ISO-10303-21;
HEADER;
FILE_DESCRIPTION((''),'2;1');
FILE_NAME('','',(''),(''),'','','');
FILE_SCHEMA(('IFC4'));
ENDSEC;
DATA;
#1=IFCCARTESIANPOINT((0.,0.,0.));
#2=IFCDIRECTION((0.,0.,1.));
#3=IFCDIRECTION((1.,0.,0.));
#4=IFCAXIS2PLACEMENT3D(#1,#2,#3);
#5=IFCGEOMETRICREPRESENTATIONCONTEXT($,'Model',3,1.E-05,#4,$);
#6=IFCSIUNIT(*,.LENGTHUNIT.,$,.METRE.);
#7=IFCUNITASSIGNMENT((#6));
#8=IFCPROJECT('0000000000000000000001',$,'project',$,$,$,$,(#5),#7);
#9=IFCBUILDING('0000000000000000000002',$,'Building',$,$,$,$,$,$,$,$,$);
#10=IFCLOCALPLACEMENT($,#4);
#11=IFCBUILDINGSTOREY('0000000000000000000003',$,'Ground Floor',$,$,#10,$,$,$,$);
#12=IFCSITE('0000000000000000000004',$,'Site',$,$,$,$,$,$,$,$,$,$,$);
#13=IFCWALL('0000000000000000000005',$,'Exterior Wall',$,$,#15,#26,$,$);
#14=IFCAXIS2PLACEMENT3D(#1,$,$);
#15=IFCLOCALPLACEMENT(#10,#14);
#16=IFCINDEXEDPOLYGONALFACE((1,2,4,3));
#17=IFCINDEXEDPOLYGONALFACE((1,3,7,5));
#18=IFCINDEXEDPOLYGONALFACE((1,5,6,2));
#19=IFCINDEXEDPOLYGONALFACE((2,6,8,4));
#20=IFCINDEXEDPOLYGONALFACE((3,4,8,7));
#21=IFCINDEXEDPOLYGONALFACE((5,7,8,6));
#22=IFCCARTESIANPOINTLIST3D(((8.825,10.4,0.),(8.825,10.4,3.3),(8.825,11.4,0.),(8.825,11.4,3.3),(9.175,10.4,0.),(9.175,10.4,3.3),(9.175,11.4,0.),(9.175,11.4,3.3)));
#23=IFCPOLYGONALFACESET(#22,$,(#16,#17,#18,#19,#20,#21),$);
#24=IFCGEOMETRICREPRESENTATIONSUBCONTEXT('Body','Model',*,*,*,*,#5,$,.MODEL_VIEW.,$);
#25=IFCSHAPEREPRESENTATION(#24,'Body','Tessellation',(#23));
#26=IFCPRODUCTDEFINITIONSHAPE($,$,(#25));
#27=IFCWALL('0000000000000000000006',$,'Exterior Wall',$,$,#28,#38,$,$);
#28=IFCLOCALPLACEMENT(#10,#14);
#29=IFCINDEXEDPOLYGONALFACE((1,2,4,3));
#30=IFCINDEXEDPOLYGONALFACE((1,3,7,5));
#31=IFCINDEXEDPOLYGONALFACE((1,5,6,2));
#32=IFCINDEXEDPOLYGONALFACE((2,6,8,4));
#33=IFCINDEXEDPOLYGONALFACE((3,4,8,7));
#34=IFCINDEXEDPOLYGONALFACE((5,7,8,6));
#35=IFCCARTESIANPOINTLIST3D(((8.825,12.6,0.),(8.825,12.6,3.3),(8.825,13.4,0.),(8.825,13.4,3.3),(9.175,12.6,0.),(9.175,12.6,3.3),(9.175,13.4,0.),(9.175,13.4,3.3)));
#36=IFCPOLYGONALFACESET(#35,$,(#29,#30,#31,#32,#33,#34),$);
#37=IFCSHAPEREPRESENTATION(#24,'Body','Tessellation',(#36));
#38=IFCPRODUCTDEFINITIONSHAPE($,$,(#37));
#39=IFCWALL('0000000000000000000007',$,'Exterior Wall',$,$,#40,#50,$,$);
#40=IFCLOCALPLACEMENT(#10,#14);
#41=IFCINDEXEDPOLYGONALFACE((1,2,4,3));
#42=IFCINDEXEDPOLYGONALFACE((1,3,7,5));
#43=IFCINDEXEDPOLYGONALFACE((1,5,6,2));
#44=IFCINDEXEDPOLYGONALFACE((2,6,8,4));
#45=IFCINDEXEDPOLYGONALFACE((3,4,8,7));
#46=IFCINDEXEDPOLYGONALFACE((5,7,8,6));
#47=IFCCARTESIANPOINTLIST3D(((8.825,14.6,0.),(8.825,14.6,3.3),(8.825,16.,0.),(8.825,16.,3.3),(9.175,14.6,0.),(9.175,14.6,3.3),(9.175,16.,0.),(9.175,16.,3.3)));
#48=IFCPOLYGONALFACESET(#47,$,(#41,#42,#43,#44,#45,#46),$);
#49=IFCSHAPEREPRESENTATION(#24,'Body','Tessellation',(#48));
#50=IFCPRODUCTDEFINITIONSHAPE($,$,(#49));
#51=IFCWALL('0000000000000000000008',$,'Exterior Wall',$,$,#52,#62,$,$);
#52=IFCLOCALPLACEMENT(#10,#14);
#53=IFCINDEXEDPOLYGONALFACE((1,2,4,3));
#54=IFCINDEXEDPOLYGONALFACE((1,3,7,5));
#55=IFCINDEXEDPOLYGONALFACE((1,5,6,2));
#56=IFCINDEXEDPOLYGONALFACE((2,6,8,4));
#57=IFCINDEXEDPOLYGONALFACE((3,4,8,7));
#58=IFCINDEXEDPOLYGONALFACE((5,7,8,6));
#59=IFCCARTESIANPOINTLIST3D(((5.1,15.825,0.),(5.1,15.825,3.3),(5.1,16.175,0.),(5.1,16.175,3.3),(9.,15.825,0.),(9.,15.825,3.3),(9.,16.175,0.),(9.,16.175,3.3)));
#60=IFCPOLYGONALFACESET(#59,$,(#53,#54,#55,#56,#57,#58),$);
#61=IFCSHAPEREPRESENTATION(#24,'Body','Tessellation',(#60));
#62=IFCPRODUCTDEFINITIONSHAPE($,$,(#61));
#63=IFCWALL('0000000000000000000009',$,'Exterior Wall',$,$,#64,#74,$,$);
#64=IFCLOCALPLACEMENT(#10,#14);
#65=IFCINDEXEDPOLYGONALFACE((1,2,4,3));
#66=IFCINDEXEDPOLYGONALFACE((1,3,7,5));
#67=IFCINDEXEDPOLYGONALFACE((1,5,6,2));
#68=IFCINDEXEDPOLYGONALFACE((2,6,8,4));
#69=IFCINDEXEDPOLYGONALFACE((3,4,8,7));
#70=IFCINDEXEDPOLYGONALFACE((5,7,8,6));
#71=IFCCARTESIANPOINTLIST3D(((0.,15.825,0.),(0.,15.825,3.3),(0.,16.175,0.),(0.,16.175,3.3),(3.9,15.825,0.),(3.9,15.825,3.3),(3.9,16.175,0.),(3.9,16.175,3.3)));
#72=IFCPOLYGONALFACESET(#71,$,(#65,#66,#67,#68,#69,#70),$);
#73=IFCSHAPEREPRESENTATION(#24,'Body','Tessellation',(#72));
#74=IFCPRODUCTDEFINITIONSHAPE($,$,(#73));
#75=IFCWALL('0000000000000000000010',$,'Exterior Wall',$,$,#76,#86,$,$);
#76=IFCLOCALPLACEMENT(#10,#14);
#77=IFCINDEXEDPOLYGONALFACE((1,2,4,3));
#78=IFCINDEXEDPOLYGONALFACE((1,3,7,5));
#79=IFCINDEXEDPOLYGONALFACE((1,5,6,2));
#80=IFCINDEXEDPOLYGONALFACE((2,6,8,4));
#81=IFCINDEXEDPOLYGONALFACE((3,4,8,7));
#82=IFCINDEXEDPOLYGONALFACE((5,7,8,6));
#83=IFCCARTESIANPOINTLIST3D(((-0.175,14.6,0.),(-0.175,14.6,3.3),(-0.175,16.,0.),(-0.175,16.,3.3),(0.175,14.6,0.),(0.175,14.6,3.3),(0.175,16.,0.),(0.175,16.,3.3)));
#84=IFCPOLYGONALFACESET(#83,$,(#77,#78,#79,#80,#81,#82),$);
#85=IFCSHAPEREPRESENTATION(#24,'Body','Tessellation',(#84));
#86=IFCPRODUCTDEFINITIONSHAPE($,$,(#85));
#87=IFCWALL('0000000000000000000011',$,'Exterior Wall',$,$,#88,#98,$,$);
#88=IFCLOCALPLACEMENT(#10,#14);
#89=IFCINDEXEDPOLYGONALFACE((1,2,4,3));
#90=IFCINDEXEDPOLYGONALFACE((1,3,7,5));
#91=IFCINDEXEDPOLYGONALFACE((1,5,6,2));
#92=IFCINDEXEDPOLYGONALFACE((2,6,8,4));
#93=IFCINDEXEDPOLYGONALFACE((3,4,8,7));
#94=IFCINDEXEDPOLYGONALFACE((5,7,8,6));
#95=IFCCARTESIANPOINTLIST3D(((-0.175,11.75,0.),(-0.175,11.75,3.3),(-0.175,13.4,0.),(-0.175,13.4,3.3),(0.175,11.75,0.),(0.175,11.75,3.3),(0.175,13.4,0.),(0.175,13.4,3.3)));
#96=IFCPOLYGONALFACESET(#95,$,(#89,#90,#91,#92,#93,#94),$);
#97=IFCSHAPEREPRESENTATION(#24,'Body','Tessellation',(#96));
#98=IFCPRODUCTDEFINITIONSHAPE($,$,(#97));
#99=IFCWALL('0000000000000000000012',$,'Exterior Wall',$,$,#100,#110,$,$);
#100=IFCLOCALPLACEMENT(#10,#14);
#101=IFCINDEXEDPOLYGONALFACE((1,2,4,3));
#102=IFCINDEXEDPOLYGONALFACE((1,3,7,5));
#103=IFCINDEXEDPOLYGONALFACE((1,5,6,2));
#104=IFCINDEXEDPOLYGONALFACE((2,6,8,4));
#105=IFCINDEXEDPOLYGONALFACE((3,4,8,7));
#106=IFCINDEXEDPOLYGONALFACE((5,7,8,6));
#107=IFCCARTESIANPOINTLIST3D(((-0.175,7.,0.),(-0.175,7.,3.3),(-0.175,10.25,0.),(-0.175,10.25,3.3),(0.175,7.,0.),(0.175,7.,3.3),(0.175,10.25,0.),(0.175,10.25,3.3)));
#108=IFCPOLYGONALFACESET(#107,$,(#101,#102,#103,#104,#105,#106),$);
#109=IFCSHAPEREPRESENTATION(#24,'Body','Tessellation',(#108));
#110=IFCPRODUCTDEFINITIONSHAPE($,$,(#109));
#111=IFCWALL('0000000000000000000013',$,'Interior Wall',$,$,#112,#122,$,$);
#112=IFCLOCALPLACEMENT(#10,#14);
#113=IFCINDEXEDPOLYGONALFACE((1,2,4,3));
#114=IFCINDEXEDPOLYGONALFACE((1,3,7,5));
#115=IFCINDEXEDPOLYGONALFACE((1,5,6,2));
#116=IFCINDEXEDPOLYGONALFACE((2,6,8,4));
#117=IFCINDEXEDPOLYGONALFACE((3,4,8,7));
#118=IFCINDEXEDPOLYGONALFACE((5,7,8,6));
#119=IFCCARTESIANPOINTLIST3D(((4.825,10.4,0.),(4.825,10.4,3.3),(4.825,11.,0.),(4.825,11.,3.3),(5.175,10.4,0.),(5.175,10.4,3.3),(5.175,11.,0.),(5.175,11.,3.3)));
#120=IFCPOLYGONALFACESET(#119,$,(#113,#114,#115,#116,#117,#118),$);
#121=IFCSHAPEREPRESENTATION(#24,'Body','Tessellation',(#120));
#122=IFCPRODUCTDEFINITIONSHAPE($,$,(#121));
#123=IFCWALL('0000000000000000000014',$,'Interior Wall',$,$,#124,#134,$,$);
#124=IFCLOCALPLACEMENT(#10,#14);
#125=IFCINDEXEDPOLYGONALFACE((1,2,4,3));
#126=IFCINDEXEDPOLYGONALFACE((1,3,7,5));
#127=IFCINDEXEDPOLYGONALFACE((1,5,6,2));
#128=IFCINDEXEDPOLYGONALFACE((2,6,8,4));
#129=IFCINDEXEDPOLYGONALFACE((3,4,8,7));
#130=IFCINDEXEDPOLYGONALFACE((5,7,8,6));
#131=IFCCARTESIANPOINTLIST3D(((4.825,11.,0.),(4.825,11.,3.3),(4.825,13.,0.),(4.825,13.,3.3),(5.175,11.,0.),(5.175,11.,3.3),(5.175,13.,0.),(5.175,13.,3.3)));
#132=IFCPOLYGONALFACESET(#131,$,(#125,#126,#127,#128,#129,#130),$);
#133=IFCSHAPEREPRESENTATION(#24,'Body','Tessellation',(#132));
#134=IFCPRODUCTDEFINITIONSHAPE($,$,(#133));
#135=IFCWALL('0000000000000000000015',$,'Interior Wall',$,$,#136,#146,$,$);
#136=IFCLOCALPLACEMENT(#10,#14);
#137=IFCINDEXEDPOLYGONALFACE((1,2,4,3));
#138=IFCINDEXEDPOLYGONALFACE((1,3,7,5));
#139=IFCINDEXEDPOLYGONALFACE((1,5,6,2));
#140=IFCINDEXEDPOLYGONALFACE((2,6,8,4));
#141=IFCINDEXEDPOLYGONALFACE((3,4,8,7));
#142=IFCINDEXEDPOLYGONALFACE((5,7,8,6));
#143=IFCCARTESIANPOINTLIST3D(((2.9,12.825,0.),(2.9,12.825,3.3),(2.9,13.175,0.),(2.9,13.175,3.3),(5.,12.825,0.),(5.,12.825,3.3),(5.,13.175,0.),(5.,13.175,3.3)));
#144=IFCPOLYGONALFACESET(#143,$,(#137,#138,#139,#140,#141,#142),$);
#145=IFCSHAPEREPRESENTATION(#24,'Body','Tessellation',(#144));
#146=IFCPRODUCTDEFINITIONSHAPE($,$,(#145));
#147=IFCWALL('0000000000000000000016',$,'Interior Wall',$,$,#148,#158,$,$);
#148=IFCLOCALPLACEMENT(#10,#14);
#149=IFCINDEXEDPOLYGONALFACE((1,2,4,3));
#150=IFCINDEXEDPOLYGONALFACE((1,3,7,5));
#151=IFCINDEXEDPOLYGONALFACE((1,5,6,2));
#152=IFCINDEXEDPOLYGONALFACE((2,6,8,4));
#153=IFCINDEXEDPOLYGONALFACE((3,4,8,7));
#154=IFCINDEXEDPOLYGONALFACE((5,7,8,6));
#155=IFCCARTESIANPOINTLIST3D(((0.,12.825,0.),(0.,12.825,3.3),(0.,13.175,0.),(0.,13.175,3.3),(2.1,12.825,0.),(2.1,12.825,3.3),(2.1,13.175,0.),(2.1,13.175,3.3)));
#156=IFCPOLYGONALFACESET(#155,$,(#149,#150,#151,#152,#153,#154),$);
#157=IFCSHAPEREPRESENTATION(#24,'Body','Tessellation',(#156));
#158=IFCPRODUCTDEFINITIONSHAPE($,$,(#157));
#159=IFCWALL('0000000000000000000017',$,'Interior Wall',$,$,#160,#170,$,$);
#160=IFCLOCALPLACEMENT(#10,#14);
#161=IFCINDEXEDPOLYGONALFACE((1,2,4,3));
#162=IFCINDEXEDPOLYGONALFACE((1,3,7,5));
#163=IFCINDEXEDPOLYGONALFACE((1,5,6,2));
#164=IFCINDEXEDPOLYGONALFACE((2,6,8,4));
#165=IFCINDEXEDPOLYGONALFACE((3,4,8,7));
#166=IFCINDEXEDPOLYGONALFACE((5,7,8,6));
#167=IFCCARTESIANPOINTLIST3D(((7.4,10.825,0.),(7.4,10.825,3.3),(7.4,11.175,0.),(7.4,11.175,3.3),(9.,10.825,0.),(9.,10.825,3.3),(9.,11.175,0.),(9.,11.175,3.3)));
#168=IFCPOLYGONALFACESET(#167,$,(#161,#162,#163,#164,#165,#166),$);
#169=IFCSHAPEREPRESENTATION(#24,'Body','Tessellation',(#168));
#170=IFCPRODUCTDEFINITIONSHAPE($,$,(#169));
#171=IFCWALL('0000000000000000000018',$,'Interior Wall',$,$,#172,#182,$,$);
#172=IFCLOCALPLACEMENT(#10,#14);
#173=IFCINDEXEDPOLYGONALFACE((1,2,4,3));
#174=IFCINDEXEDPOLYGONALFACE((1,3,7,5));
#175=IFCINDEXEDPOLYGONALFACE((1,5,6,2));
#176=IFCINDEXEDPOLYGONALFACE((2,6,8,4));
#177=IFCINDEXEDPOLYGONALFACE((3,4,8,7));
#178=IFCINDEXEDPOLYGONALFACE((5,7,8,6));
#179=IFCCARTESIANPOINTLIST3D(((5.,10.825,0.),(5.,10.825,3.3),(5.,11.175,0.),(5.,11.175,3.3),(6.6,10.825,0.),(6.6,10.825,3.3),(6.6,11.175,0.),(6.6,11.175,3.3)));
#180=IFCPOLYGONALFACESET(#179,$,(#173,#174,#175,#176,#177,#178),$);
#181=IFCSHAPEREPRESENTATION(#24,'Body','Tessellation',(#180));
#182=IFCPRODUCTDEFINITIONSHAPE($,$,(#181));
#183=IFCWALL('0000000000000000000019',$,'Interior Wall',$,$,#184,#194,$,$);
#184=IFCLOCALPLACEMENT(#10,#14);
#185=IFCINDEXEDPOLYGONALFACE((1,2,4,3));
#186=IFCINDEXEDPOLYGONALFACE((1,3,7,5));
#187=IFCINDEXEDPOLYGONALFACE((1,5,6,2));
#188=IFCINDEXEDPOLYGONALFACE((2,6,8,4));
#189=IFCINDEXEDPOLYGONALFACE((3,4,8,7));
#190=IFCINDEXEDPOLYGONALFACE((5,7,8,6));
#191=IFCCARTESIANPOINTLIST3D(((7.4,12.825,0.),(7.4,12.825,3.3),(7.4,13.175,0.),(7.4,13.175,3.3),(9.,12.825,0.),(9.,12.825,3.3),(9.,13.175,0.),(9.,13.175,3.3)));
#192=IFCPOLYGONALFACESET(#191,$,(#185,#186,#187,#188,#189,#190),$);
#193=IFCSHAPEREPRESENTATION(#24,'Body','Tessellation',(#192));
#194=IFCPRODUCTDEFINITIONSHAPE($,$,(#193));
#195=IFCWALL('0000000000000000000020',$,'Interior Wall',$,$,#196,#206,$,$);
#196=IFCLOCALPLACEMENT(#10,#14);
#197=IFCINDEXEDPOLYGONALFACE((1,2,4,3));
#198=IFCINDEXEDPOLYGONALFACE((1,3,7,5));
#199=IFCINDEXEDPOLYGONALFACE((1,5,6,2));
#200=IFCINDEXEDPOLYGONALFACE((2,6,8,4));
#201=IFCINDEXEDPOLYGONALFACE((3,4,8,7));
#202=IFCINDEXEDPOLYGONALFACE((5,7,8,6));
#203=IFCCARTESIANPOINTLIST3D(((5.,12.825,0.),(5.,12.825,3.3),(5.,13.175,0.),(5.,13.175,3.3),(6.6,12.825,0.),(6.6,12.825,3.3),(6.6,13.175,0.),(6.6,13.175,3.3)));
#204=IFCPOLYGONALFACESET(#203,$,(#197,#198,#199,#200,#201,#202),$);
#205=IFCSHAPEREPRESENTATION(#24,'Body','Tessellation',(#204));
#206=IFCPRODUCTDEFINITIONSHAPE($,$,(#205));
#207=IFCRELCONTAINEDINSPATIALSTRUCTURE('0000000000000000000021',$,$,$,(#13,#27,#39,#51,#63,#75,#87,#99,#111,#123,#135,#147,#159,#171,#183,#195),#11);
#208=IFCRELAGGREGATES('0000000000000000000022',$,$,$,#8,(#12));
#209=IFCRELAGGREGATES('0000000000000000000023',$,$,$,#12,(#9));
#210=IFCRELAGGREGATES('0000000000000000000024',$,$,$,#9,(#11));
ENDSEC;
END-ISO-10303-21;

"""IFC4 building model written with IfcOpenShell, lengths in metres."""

from ifc_helpers import new_model, si_unit, frame, origin_with_axes, place, context, subcontext, project, spatial, indexed_curve, outline, extrude, element, save


model = new_model("IFC4")

# Units and contexts
model_context = context("Model", 3, precision=1e-05, world=origin_with_axes())
body_context = subcontext(model_context, "Body", "Model", "MODEL_VIEW")
ifc_project = project(units=[si_unit("LENGTHUNIT", "METRE")], contexts=[model_context])

# Site, building, storey
site = spatial("IfcSite", under=ifc_project, Name="Site")
building = spatial("IfcBuilding", under=site, Name="Building")
storey_placement = place(None, origin_with_axes())
storey = spatial("IfcBuildingStorey", under=building, at=storey_placement, Name="Ground Floor")

# Walls
wall_1_placement = place(storey_placement, frame((9.0, 10.4, 0.0), z_axis=(0.0, 0.0, 1.0), x_axis=(0.0, 1.0, 0.0)))
element("IfcWall", 1, at=wall_1_placement, inside=storey, Name="Exterior Wall", context=body_context, shape_type="SweptSolid", body=[
    extrude(outline(indexed_curve([(0.0, 0.0), (0.0, 0.35), (1.0, 0.35), (1.0, 0.0), (0.0, 0.0)], self_intersect=False)), frame((0.0, -0.175, 0.0), z_axis=(0.0, 0.0, 1.0), x_axis=(1.0, 0.0, 0.0)), (0.0, 0.0, 1.0), 3.3),
])
wall_2_placement = place(storey_placement, frame((9.0, 12.6, 0.0), z_axis=(0.0, 0.0, 1.0), x_axis=(0.0, 1.0, 0.0)))
element("IfcWall", 2, at=wall_2_placement, inside=storey, Name="Exterior Wall", context=body_context, shape_type="SweptSolid", body=[
    extrude(outline(indexed_curve([(0.0, 0.0), (0.0, 0.35), (0.8, 0.35), (0.8, 0.0), (0.0, 0.0)], self_intersect=False)), frame((0.0, -0.175, 0.0), z_axis=(0.0, 0.0, 1.0), x_axis=(1.0, 0.0, 0.0)), (0.0, 0.0, 1.0), 3.3),
])
wall_3_placement = place(storey_placement, frame((9.0, 14.6, 0.0), z_axis=(0.0, 0.0, 1.0), x_axis=(0.0, 1.0, 0.0)))
element("IfcWall", 3, at=wall_3_placement, inside=storey, Name="Exterior Wall", context=body_context, shape_type="SweptSolid", body=[
    extrude(outline(indexed_curve([(0.0, 0.0), (0.0, 0.35), (1.4, 0.35), (1.4, 0.0), (0.0, 0.0)], self_intersect=False)), frame((0.0, -0.175, 0.0), z_axis=(0.0, 0.0, 1.0), x_axis=(1.0, 0.0, 0.0)), (0.0, 0.0, 1.0), 3.3),
])
for number, where, z_axis, x_axis, name in (
    (4, (9.0, 16.0, 0.0), (0.0, 0.0, 1.0), (-1.0, 0.0, 0.0), "Exterior Wall"),
    (5, (3.9, 16.0, 0.0), (0.0, 0.0, 1.0), (-1.0, 0.0, 0.0), "Exterior Wall"),
):
    element("IfcWall", number, at=place(storey_placement, frame(where, z_axis=z_axis, x_axis=x_axis)), inside=storey, Name=name, context=body_context, shape_type="SweptSolid", body=[
        extrude(outline(indexed_curve([(0.0, 0.0), (0.0, 0.35), (3.9, 0.35), (3.9, 0.0), (0.0, 0.0)], self_intersect=False)), frame((0.0, -0.175, 0.0), z_axis=(0.0, 0.0, 1.0), x_axis=(1.0, 0.0, 0.0)), (0.0, 0.0, 1.0), 3.3),
    ])
wall_4_placement = place(storey_placement, frame((0.0, 16.0, 0.0), z_axis=(0.0, 0.0, 1.0), x_axis=(0.0, -1.0, 0.0)))
element("IfcWall", 6, at=wall_4_placement, inside=storey, Name="Exterior Wall", context=body_context, shape_type="SweptSolid", body=[
    extrude(outline(indexed_curve([(0.0, 0.0), (0.0, 0.35), (1.4, 0.35), (1.4, 0.0), (0.0, 0.0)], self_intersect=False)), frame((0.0, -0.175, 0.0), z_axis=(0.0, 0.0, 1.0), x_axis=(1.0, 0.0, 0.0)), (0.0, 0.0, 1.0), 3.3),
])
wall_5_placement = place(storey_placement, frame((0.0, 13.4, 0.0), z_axis=(0.0, 0.0, 1.0), x_axis=(0.0, -1.0, 0.0)))
element("IfcWall", 7, at=wall_5_placement, inside=storey, Name="Exterior Wall", context=body_context, shape_type="SweptSolid", body=[
    extrude(outline(indexed_curve([(0.0, 0.0), (0.0, 0.35), (1.65, 0.35), (1.65, 0.0), (0.0, 0.0)], self_intersect=False)), frame((0.0, -0.175, 0.0), z_axis=(0.0, 0.0, 1.0), x_axis=(1.0, 0.0, 0.0)), (0.0, 0.0, 1.0), 3.3),
])
wall_6_placement = place(storey_placement, frame((0.0, 10.25, 0.0), z_axis=(0.0, 0.0, 1.0), x_axis=(0.0, -1.0, 0.0)))
element("IfcWall", 8, at=wall_6_placement, inside=storey, Name="Exterior Wall", context=body_context, shape_type="SweptSolid", body=[
    extrude(outline(indexed_curve([(0.0, 0.0), (0.0, 0.35), (3.25, 0.35), (3.25, 0.0), (0.0, 0.0)], self_intersect=False)), frame((0.0, -0.175, 0.0), z_axis=(0.0, 0.0, 1.0), x_axis=(1.0, 0.0, 0.0)), (0.0, 0.0, 1.0), 3.3),
])
wall_7_placement = place(storey_placement, frame((5.0, 10.4, 0.0), z_axis=(0.0, 0.0, 1.0), x_axis=(0.0, 1.0, 0.0)))
element("IfcWall", 9, at=wall_7_placement, inside=storey, Name="Interior Wall", context=body_context, shape_type="SweptSolid", body=[
    extrude(outline(indexed_curve([(0.0, 0.0), (0.0, 0.35), (0.6, 0.35), (0.6, 0.0), (0.0, 0.0)], self_intersect=False)), frame((0.0, -0.175, 0.0), z_axis=(0.0, 0.0, 1.0), x_axis=(1.0, 0.0, 0.0)), (0.0, 0.0, 1.0), 3.3),
])
wall_8_placement = place(storey_placement, frame((5.0, 11.0, 0.0), z_axis=(0.0, 0.0, 1.0), x_axis=(0.0, 1.0, 0.0)))
element("IfcWall", 10, at=wall_8_placement, inside=storey, Name="Interior Wall", context=body_context, shape_type="SweptSolid", body=[
    extrude(outline(indexed_curve([(0.0, 0.0), (0.0, 0.35), (2.0, 0.35), (2.0, 0.0), (0.0, 0.0)], self_intersect=False)), frame((0.0, -0.175, 0.0), z_axis=(0.0, 0.0, 1.0), x_axis=(1.0, 0.0, 0.0)), (0.0, 0.0, 1.0), 3.3),
])
for number, where, z_axis, x_axis, name in (
    (11, (5.0, 13.0, 0.0), (0.0, 0.0, 1.0), (-1.0, 0.0, 0.0), "Interior Wall"),
    (12, (2.1, 13.0, 0.0), (0.0, 0.0, 1.0), (-1.0, 0.0, 0.0), "Interior Wall"),
):
    element("IfcWall", number, at=place(storey_placement, frame(where, z_axis=z_axis, x_axis=x_axis)), inside=storey, Name=name, context=body_context, shape_type="SweptSolid", body=[
        extrude(outline(indexed_curve([(0.0, 0.0), (0.0, 0.35), (2.1, 0.35), (2.1, 0.0), (0.0, 0.0)], self_intersect=False)), frame((0.0, -0.175, 0.0), z_axis=(0.0, 0.0, 1.0), x_axis=(1.0, 0.0, 0.0)), (0.0, 0.0, 1.0), 3.3),
    ])
for number, where, z_axis, x_axis, name in (
    (13, (9.0, 11.0, 0.0), (0.0, 0.0, 1.0), (-1.0, 0.0, 0.0), "Interior Wall"),
    (14, (6.6, 11.0, 0.0), (0.0, 0.0, 1.0), (-1.0, 0.0, 0.0), "Interior Wall"),
    (15, (9.0, 13.0, 0.0), (0.0, 0.0, 1.0), (-1.0, 0.0, 0.0), "Interior Wall"),
    (16, (6.6, 13.0, 0.0), (0.0, 0.0, 1.0), (-1.0, 0.0, 0.0), "Interior Wall"),
):
    element("IfcWall", number, at=place(storey_placement, frame(where, z_axis=z_axis, x_axis=x_axis)), inside=storey, Name=name, context=body_context, shape_type="SweptSolid", body=[
        extrude(outline(indexed_curve([(0.0, 0.0), (0.0, 0.35), (1.6, 0.35), (1.6, 0.0), (0.0, 0.0)], self_intersect=False)), frame((0.0, -0.175, 0.0), z_axis=(0.0, 0.0, 1.0), x_axis=(1.0, 0.0, 0.0)), (0.0, 0.0, 1.0), 3.3),
    ])

save(model, "model.ifc")
